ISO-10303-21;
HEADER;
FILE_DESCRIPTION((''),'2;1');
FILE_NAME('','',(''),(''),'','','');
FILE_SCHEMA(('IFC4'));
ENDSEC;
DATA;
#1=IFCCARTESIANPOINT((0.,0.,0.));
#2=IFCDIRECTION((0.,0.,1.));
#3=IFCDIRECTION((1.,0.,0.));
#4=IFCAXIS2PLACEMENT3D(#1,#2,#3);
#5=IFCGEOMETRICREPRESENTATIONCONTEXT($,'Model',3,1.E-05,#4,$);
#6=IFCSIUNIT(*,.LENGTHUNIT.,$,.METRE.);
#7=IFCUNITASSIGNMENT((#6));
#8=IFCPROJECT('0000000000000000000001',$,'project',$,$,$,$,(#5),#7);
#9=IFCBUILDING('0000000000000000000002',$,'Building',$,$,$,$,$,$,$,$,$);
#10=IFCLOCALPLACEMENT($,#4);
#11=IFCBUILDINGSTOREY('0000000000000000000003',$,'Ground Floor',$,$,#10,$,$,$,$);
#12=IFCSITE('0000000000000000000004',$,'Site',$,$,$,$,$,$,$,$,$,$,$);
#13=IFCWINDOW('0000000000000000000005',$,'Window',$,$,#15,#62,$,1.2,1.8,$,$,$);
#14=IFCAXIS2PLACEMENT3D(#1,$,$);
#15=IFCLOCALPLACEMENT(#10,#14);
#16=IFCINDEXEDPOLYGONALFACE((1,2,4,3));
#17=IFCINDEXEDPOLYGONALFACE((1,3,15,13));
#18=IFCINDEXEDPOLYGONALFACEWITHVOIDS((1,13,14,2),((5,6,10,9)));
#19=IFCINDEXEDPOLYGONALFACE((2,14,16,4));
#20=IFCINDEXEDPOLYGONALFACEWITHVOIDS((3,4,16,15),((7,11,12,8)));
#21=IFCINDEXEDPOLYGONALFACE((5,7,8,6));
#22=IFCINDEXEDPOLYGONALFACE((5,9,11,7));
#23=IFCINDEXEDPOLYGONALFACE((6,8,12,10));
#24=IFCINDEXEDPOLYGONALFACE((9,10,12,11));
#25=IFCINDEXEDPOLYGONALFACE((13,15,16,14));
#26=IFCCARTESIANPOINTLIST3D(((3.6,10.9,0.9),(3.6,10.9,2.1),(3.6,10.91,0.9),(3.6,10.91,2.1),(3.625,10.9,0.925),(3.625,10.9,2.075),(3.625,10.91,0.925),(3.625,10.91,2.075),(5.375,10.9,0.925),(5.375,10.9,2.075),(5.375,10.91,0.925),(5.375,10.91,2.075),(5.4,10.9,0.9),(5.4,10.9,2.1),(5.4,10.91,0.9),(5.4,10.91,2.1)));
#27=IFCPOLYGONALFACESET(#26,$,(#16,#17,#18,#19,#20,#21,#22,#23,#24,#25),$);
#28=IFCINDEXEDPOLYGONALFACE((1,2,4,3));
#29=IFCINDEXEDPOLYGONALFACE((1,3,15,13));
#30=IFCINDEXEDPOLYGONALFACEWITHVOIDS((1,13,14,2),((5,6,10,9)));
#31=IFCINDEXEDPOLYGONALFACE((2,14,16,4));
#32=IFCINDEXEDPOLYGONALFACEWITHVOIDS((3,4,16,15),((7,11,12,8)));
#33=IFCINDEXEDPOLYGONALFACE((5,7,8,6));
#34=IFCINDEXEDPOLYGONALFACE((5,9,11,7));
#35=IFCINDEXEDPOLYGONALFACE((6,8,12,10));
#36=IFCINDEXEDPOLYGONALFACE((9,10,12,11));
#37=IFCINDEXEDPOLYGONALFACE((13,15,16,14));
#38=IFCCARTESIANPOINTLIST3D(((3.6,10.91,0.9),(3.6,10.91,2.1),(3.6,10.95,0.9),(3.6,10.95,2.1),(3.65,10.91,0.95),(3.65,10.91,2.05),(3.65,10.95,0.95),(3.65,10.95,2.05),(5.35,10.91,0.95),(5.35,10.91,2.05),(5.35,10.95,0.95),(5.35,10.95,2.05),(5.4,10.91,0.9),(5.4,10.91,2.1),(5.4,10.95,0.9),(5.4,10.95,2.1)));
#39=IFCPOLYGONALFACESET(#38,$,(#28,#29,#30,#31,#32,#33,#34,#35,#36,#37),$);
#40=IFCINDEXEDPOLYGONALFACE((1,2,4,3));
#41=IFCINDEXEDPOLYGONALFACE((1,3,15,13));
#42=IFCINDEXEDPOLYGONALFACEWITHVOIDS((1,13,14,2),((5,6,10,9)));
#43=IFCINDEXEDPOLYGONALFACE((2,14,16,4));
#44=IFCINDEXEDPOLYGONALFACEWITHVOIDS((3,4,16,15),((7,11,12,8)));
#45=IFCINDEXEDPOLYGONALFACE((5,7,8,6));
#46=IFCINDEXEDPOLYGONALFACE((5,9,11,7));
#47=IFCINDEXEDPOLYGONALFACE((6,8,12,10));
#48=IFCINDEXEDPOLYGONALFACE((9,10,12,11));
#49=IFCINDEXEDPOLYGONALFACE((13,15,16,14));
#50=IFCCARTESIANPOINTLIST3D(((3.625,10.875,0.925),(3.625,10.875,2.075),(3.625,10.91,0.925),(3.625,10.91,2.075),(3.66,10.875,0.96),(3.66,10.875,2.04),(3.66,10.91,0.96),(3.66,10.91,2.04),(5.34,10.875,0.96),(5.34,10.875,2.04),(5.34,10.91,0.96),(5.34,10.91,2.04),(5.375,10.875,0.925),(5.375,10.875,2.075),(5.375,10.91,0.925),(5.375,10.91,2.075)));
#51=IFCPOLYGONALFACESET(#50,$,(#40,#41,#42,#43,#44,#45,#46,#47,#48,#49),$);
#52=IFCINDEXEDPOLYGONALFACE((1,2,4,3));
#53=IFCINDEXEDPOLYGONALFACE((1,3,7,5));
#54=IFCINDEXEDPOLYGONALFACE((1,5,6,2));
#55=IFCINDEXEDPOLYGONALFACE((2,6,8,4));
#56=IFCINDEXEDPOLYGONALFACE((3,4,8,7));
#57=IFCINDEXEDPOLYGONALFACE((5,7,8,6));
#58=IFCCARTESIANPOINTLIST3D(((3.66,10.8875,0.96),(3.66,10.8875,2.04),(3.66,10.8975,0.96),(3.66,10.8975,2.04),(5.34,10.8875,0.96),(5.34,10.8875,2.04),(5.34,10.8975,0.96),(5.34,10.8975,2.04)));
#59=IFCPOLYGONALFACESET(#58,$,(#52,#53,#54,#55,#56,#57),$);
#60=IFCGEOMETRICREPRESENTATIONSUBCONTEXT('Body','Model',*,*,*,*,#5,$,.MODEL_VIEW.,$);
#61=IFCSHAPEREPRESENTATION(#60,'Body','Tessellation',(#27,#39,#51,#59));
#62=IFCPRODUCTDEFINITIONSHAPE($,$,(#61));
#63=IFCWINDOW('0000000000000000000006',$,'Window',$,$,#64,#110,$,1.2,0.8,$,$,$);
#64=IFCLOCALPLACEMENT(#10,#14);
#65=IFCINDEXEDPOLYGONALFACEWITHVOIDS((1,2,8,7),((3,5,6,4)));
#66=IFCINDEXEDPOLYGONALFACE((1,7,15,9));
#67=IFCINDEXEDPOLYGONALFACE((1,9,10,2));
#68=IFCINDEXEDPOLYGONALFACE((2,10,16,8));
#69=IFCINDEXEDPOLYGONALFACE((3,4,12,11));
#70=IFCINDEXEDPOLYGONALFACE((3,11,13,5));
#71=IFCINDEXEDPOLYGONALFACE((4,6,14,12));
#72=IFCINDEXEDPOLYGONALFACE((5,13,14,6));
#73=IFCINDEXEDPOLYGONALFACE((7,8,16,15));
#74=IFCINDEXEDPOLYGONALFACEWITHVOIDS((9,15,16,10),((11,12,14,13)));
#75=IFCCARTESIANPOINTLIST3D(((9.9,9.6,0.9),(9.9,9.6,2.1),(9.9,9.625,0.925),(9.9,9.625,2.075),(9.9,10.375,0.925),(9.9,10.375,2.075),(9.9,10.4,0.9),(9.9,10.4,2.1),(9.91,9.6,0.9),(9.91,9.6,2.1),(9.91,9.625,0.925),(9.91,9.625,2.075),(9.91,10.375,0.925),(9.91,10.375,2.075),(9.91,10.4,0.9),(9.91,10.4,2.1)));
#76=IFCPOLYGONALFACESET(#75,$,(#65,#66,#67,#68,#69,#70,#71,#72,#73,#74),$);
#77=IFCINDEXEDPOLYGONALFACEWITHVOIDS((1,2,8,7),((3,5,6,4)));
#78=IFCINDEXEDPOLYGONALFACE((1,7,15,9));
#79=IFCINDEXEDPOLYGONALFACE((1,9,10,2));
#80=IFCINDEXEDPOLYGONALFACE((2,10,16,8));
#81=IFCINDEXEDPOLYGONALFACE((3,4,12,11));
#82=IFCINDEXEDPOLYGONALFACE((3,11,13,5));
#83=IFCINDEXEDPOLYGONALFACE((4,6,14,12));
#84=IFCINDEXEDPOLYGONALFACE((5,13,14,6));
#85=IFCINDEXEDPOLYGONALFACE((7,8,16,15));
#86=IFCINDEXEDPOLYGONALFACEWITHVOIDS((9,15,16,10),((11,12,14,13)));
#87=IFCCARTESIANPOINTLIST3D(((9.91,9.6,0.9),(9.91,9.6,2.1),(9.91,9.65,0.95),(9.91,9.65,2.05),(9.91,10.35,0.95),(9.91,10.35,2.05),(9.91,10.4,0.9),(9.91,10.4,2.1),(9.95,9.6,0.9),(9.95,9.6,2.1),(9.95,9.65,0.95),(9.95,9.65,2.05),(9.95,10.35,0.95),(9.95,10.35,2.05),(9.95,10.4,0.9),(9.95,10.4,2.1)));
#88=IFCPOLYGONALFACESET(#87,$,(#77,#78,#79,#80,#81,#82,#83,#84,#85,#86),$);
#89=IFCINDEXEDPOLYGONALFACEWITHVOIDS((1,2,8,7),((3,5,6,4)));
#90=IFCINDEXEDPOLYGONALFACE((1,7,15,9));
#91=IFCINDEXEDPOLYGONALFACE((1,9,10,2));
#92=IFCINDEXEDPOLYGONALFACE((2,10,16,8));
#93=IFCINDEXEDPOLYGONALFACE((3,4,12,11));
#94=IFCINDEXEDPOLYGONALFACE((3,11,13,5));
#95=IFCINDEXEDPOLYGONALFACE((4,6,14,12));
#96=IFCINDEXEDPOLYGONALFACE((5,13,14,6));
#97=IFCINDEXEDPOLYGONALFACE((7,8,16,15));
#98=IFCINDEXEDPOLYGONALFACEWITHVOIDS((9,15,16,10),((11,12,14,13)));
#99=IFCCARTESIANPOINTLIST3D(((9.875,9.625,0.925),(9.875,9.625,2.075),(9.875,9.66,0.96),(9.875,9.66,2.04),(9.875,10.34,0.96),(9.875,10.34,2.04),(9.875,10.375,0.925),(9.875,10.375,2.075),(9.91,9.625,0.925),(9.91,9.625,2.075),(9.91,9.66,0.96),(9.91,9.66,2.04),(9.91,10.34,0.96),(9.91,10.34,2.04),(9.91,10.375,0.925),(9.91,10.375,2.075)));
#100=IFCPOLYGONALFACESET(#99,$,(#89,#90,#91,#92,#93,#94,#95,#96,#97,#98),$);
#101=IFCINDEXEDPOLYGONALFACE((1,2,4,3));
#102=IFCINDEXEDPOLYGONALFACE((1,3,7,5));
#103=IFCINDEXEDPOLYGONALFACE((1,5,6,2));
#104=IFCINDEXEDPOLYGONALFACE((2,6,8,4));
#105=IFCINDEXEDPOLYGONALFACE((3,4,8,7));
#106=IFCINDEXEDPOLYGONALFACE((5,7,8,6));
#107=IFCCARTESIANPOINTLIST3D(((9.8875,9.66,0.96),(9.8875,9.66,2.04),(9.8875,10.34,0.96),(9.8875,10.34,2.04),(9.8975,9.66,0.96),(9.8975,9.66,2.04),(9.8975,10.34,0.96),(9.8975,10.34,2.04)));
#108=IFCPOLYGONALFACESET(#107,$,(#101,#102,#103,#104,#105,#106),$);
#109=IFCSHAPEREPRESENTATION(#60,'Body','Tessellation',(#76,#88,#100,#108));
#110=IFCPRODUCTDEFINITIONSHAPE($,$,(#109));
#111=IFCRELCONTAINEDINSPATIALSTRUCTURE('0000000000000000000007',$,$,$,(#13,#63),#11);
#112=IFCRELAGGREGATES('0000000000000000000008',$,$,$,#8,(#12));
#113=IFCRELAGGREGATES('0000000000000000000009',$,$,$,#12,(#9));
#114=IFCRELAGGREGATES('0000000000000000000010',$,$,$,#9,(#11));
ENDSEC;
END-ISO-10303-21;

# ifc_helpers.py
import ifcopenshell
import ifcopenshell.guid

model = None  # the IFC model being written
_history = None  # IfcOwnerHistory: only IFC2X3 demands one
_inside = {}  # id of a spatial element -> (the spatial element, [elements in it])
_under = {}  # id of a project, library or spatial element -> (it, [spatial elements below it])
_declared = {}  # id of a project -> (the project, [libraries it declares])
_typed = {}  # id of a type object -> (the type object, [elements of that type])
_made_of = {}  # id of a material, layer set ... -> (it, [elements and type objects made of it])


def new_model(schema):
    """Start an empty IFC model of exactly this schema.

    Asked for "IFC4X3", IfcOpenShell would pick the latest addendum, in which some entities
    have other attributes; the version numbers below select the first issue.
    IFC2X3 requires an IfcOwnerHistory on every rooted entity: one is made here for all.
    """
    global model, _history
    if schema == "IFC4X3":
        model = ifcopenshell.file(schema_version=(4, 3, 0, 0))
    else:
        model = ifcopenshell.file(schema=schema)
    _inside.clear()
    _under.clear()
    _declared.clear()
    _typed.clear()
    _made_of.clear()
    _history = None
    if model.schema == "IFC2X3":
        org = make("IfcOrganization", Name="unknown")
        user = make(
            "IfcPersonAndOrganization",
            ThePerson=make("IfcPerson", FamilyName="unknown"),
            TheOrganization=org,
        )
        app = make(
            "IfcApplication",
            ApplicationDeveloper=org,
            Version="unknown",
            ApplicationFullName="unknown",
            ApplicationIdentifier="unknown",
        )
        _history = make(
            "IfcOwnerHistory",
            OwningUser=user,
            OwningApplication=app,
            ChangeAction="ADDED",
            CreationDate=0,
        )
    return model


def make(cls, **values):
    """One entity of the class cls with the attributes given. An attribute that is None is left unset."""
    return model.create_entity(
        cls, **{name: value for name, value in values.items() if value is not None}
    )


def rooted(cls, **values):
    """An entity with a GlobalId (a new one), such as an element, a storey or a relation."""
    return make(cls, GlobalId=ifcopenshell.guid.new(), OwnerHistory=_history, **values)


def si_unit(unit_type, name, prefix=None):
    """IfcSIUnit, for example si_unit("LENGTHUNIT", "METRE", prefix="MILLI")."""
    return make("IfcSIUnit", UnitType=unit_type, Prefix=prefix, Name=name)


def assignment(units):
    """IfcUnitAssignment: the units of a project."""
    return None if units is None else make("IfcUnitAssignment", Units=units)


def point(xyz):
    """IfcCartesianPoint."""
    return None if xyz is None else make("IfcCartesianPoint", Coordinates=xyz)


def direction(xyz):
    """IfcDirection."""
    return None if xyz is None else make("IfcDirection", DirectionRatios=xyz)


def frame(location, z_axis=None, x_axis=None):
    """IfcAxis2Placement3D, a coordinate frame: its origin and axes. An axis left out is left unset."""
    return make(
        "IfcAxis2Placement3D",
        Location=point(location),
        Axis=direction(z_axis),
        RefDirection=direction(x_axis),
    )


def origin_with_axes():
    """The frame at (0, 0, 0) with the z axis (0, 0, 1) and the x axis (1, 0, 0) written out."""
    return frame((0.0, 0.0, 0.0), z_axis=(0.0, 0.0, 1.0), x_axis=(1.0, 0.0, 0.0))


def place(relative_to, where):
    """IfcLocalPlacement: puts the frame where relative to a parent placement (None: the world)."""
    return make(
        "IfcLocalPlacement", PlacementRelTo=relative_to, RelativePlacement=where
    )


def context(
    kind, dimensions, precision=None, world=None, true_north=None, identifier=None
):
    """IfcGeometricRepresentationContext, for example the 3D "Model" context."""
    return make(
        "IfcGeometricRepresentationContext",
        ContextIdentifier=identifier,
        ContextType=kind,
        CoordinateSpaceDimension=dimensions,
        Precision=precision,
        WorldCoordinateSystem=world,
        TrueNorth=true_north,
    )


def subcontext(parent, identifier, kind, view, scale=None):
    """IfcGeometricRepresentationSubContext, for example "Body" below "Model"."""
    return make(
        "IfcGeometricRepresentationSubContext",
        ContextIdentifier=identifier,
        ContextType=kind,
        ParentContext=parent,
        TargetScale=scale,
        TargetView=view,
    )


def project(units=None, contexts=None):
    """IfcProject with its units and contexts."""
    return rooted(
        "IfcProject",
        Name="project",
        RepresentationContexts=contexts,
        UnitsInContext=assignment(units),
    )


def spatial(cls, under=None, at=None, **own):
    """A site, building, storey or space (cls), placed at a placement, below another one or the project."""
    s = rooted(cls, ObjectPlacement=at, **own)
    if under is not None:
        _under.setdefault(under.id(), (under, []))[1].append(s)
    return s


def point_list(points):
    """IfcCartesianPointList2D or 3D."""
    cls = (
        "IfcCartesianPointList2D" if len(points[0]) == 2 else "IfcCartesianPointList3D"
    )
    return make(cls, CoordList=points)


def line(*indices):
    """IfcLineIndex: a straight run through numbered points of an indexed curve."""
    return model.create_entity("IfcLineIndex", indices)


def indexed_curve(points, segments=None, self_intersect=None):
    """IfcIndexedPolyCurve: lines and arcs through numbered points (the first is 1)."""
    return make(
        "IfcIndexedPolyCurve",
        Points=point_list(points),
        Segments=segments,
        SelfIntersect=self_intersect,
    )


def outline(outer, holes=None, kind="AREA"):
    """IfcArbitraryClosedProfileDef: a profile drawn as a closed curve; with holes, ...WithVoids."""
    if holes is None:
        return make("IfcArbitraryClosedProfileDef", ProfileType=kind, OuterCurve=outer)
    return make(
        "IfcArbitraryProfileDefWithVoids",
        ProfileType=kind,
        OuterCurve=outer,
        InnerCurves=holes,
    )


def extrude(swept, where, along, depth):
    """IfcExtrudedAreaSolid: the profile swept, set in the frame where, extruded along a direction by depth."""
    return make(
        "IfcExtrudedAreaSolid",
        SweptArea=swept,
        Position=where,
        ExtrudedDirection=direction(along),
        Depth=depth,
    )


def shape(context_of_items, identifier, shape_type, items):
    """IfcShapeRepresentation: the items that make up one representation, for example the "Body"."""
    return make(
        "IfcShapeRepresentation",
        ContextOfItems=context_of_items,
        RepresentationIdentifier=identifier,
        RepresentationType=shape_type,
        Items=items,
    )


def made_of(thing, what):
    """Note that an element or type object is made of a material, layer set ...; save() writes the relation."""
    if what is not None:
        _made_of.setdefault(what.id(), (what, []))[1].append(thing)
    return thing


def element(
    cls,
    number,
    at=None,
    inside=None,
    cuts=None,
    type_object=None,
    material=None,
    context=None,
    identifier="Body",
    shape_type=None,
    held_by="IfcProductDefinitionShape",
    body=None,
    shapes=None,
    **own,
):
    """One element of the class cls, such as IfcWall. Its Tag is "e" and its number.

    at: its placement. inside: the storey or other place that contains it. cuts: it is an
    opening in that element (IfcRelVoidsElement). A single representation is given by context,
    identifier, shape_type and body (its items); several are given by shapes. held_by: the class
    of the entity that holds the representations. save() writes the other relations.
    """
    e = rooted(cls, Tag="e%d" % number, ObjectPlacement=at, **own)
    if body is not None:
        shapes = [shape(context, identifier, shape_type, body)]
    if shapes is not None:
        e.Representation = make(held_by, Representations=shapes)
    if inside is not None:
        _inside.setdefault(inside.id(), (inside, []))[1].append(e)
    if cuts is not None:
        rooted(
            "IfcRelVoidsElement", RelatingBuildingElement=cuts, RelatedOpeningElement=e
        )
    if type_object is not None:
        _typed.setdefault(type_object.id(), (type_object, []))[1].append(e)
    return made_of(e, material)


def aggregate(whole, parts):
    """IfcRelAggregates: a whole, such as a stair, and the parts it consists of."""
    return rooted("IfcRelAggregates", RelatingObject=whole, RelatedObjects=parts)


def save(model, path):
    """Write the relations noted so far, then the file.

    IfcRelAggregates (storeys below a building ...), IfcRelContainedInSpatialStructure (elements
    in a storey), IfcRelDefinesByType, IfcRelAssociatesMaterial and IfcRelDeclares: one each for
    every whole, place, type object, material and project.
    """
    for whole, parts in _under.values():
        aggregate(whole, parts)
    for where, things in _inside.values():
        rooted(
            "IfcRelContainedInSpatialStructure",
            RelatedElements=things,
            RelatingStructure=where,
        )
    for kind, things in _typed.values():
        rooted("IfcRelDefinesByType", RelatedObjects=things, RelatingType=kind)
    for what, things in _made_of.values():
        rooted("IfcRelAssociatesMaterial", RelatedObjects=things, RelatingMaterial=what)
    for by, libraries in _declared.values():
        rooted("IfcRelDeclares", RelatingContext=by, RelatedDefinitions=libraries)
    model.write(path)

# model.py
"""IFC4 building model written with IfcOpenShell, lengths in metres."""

from ifc_helpers import new_model, si_unit, frame, origin_with_axes, place, context, subcontext, project, spatial, line, indexed_curve, outline, extrude, element, save


model = new_model("IFC4")

# Units and contexts
model_context = context("Model", 3, precision=1e-05, world=origin_with_axes())
body_context = subcontext(model_context, "Body", "Model", "MODEL_VIEW")
ifc_project = project(units=[si_unit("LENGTHUNIT", "METRE")], contexts=[model_context])

# Site, building, storey
site = spatial("IfcSite", under=ifc_project, Name="Site")
building = spatial("IfcBuilding", under=site, Name="Building")
storey_placement = place(None, origin_with_axes())
storey = spatial("IfcBuildingStorey", under=building, at=storey_placement, Name="Ground Floor")

# Windows
window_1_placement = place(storey_placement, frame((5.4, 11.0, 0.9), z_axis=(0.0, 0.0, 1.0), x_axis=(-1.0, 0.0, 0.0)))
element("IfcWindow", 1, at=window_1_placement, inside=storey, Name="Window", OverallHeight=1.2, OverallWidth=1.8, context=body_context, shape_type="SweptSolid", body=[
    extrude(outline(indexed_curve([(0.0, 0.0), (1.8, 0.0), (1.8, 1.2), (0.0, 1.2)], segments=[line(1, 2, 3, 4, 1)]), holes=[indexed_curve([(0.025, 0.025), (1.775, 0.025), (1.775, 1.175), (0.025, 1.175)], segments=[line(1, 2, 3, 4, 1)])]), frame((0.0, 0.09, 0.0), z_axis=(0.0, -1.0, 0.0), x_axis=(1.0, 0.0, 0.0)), (0.0, 0.0, -1.0), 0.01),
    extrude(outline(indexed_curve([(0.0, 0.0), (1.8, 0.0), (1.8, 1.2), (0.0, 1.2)], segments=[line(1, 2, 3, 4, 1)]), holes=[indexed_curve([(0.05, 0.05), (1.75, 0.05), (1.75, 1.15), (0.05, 1.15)], segments=[line(1, 2, 3, 4, 1)])]), frame((0.0, 0.05, 0.0), z_axis=(0.0, -1.0, 0.0), x_axis=(1.0, 0.0, 0.0)), (0.0, 0.0, -1.0), 0.04),
    extrude(outline(indexed_curve([(0.0, 0.0), (1.75, 0.0), (1.75, 1.15), (0.0, 1.15)], segments=[line(1, 2, 3, 4, 1)]), holes=[indexed_curve([(0.035, 0.035), (1.715, 0.035), (1.715, 1.115), (0.035, 1.115)], segments=[line(1, 2, 3, 4, 1)])]), frame((0.025, 0.09, 0.025), z_axis=(0.0, -1.0, 0.0), x_axis=(1.0, 0.0, 0.0)), (0.0, 0.0, -1.0), 0.035),
    extrude(outline(indexed_curve([(0.035, 0.035), (1.715, 0.035), (1.715, 1.115), (0.035, 1.115)], segments=[line(1, 2, 3, 4, 1)])), frame((0.025, 0.1025, 0.025), z_axis=(0.0, -1.0, 0.0), x_axis=(1.0, 0.0, 0.0)), (0.0, 0.0, -1.0), 0.01),
])
window_2_placement = place(storey_placement, frame((10.0, 9.6, 0.9), z_axis=(0.0, 0.0, 1.0), x_axis=(0.0, 1.0, 0.0)))
element("IfcWindow", 2, at=window_2_placement, inside=storey, Name="Window", OverallHeight=1.2, OverallWidth=0.8, context=body_context, shape_type="SweptSolid", body=[
    extrude(outline(indexed_curve([(0.0, 0.0), (0.8, 0.0), (0.8, 1.2), (0.0, 1.2)], segments=[line(1, 2, 3, 4, 1)]), holes=[indexed_curve([(0.025, 0.025), (0.775, 0.025), (0.775, 1.175), (0.025, 1.175)], segments=[line(1, 2, 3, 4, 1)])]), frame((0.0, 0.09, 0.0), z_axis=(0.0, -1.0, 0.0), x_axis=(1.0, 0.0, 0.0)), (0.0, 0.0, -1.0), 0.01),
    extrude(outline(indexed_curve([(0.0, 0.0), (0.8, 0.0), (0.8, 1.2), (0.0, 1.2)], segments=[line(1, 2, 3, 4, 1)]), holes=[indexed_curve([(0.05, 0.05), (0.75, 0.05), (0.75, 1.15), (0.05, 1.15)], segments=[line(1, 2, 3, 4, 1)])]), frame((0.0, 0.05, 0.0), z_axis=(0.0, -1.0, 0.0), x_axis=(1.0, 0.0, 0.0)), (0.0, 0.0, -1.0), 0.04),
    extrude(outline(indexed_curve([(0.0, 0.0), (0.75, 0.0), (0.75, 1.15), (0.0, 1.15)], segments=[line(1, 2, 3, 4, 1)]), holes=[indexed_curve([(0.035, 0.035), (0.715, 0.035), (0.715, 1.115), (0.035, 1.115)], segments=[line(1, 2, 3, 4, 1)])]), frame((0.025, 0.09, 0.025), z_axis=(0.0, -1.0, 0.0), x_axis=(1.0, 0.0, 0.0)), (0.0, 0.0, -1.0), 0.035),
    extrude(outline(indexed_curve([(0.035, 0.035), (0.715, 0.035), (0.715, 1.115), (0.035, 1.115)], segments=[line(1, 2, 3, 4, 1)])), frame((0.025, 0.1025, 0.025), z_axis=(0.0, -1.0, 0.0), x_axis=(1.0, 0.0, 0.0)), (0.0, 0.0, -1.0), 0.01),
])

save(model, "model.ifc")
